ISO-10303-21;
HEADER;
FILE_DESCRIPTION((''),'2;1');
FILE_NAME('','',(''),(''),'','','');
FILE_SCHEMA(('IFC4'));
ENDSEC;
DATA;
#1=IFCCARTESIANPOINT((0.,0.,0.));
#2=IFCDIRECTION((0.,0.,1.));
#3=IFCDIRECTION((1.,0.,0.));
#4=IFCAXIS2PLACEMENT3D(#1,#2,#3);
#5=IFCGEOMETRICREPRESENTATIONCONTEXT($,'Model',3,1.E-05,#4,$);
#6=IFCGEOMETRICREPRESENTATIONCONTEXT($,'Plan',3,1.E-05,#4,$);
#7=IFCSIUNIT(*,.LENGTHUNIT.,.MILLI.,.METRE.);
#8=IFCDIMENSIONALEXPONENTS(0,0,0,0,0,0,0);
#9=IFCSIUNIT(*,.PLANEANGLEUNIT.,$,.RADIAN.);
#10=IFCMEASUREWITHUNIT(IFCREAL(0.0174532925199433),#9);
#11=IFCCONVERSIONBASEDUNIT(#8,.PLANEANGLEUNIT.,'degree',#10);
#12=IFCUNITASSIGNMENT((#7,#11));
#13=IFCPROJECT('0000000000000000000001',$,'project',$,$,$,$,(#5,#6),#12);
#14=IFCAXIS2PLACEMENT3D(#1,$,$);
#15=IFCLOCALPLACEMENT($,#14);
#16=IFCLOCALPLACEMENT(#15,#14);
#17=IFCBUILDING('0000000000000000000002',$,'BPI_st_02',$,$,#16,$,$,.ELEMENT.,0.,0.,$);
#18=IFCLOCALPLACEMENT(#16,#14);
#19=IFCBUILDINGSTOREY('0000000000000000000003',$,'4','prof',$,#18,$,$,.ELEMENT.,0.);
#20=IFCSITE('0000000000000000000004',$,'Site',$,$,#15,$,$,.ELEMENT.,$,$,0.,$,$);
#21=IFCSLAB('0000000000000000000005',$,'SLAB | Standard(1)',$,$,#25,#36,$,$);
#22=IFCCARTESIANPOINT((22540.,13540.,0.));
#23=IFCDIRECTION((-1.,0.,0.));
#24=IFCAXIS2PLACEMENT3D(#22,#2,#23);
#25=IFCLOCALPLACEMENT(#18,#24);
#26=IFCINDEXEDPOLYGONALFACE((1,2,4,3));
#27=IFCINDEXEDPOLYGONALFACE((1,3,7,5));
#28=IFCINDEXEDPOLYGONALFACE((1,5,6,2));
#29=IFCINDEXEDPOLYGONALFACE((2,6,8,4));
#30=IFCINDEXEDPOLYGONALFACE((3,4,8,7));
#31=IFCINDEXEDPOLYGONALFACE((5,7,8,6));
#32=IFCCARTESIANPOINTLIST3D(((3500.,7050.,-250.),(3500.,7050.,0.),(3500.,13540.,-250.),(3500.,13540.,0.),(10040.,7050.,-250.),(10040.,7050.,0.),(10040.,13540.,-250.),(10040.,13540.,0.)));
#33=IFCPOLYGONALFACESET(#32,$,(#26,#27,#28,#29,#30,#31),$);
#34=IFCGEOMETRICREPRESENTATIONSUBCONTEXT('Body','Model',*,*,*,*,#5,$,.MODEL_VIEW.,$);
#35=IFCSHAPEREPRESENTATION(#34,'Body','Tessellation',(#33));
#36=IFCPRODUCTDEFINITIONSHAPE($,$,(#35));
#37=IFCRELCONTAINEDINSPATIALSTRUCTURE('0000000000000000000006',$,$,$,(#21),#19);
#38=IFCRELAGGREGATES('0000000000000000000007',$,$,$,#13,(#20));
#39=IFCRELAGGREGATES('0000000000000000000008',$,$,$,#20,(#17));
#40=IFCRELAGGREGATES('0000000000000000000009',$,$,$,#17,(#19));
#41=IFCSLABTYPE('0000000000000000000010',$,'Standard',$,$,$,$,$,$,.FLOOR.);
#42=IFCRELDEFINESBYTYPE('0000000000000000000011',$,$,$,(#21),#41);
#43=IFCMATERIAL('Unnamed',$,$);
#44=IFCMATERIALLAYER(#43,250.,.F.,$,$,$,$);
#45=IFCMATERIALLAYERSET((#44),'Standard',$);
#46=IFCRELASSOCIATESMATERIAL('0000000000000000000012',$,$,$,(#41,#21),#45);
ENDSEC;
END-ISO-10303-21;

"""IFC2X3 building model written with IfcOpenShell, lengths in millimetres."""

from ifc_helpers import new_model, entity, si_unit, converted_unit, frame, frame_2d, origin, origin_with_axes, place, context, subcontext, project, spatial, rectangle, extrude, material, layer, layer_set, layer_usage, type_object, element, save


model = new_model("IFC2X3")

# Units and contexts
model_context = context("Model", 3, precision=1e-05, world=origin_with_axes())
plan_context = context("Plan", 3, precision=1e-05, world=origin_with_axes())
body_context = subcontext(model_context, "Body", "Model", "MODEL_VIEW")
ifc_project = project(units=[si_unit("LENGTHUNIT", "METRE", prefix="MILLI"), converted_unit("PLANEANGLEUNIT", "degree", entity("IfcReal", 0.0174532925199433), si_unit("PLANEANGLEUNIT", "RADIAN"), dimensions=[0, 0, 0, 0, 0, 0, 0])], contexts=[model_context, plan_context])

# Site, building, storey
site_placement = place(None, origin())
site = spatial("IfcSite", under=ifc_project, at=site_placement, Name="Site", CompositionType="ELEMENT", RefElevation=0.0)
building_placement = place(site_placement, origin())
building = spatial("IfcBuilding", under=site, at=building_placement, Name="BPI_st_02", CompositionType="ELEMENT", ElevationOfRefHeight=0.0, ElevationOfTerrain=0.0)
storey_placement = place(building_placement, origin())
storey = spatial("IfcBuildingStorey", under=building, at=storey_placement, Name="4", Description="prof", CompositionType="ELEMENT", Elevation=0.0)

# Slab
ifc_material = material(Name="Unnamed")
ifc_layer_1 = layer(ifc_material, 250.0, ventilated=False)
ifc_layer_set_1 = layer_set([ifc_layer_1], Name="Standard")
ifc_layer_usage_1 = layer_usage(ifc_layer_set_1, "AXIS3", "POSITIVE", 0.0)
slab_type = type_object("IfcSlabType", Name="Standard", PredefinedType="FLOOR", material=ifc_layer_set_1)
slab_placement = place(storey_placement, frame((22540.0, 13540.0, 0.0), z_axis=(0.0, 0.0, 1.0), x_axis=(-1.0, 0.0, 0.0)))
element("IfcSlab", 1, at=slab_placement, inside=storey, type_object=slab_type, material=ifc_layer_usage_1, Name="SLAB | Standard(1)", context=body_context, shape_type="SweptSolid", body=[
    extrude(rectangle(XDim=6540.0, YDim=6490.0, at=frame_2d((6770.0, 10295.0), x_axis=(1.0, 0.0))), frame((0.0, 0.0, -250.0)), (0.0, 0.0, 1.0), 250.0),
])

save(model, "model.ifc")
